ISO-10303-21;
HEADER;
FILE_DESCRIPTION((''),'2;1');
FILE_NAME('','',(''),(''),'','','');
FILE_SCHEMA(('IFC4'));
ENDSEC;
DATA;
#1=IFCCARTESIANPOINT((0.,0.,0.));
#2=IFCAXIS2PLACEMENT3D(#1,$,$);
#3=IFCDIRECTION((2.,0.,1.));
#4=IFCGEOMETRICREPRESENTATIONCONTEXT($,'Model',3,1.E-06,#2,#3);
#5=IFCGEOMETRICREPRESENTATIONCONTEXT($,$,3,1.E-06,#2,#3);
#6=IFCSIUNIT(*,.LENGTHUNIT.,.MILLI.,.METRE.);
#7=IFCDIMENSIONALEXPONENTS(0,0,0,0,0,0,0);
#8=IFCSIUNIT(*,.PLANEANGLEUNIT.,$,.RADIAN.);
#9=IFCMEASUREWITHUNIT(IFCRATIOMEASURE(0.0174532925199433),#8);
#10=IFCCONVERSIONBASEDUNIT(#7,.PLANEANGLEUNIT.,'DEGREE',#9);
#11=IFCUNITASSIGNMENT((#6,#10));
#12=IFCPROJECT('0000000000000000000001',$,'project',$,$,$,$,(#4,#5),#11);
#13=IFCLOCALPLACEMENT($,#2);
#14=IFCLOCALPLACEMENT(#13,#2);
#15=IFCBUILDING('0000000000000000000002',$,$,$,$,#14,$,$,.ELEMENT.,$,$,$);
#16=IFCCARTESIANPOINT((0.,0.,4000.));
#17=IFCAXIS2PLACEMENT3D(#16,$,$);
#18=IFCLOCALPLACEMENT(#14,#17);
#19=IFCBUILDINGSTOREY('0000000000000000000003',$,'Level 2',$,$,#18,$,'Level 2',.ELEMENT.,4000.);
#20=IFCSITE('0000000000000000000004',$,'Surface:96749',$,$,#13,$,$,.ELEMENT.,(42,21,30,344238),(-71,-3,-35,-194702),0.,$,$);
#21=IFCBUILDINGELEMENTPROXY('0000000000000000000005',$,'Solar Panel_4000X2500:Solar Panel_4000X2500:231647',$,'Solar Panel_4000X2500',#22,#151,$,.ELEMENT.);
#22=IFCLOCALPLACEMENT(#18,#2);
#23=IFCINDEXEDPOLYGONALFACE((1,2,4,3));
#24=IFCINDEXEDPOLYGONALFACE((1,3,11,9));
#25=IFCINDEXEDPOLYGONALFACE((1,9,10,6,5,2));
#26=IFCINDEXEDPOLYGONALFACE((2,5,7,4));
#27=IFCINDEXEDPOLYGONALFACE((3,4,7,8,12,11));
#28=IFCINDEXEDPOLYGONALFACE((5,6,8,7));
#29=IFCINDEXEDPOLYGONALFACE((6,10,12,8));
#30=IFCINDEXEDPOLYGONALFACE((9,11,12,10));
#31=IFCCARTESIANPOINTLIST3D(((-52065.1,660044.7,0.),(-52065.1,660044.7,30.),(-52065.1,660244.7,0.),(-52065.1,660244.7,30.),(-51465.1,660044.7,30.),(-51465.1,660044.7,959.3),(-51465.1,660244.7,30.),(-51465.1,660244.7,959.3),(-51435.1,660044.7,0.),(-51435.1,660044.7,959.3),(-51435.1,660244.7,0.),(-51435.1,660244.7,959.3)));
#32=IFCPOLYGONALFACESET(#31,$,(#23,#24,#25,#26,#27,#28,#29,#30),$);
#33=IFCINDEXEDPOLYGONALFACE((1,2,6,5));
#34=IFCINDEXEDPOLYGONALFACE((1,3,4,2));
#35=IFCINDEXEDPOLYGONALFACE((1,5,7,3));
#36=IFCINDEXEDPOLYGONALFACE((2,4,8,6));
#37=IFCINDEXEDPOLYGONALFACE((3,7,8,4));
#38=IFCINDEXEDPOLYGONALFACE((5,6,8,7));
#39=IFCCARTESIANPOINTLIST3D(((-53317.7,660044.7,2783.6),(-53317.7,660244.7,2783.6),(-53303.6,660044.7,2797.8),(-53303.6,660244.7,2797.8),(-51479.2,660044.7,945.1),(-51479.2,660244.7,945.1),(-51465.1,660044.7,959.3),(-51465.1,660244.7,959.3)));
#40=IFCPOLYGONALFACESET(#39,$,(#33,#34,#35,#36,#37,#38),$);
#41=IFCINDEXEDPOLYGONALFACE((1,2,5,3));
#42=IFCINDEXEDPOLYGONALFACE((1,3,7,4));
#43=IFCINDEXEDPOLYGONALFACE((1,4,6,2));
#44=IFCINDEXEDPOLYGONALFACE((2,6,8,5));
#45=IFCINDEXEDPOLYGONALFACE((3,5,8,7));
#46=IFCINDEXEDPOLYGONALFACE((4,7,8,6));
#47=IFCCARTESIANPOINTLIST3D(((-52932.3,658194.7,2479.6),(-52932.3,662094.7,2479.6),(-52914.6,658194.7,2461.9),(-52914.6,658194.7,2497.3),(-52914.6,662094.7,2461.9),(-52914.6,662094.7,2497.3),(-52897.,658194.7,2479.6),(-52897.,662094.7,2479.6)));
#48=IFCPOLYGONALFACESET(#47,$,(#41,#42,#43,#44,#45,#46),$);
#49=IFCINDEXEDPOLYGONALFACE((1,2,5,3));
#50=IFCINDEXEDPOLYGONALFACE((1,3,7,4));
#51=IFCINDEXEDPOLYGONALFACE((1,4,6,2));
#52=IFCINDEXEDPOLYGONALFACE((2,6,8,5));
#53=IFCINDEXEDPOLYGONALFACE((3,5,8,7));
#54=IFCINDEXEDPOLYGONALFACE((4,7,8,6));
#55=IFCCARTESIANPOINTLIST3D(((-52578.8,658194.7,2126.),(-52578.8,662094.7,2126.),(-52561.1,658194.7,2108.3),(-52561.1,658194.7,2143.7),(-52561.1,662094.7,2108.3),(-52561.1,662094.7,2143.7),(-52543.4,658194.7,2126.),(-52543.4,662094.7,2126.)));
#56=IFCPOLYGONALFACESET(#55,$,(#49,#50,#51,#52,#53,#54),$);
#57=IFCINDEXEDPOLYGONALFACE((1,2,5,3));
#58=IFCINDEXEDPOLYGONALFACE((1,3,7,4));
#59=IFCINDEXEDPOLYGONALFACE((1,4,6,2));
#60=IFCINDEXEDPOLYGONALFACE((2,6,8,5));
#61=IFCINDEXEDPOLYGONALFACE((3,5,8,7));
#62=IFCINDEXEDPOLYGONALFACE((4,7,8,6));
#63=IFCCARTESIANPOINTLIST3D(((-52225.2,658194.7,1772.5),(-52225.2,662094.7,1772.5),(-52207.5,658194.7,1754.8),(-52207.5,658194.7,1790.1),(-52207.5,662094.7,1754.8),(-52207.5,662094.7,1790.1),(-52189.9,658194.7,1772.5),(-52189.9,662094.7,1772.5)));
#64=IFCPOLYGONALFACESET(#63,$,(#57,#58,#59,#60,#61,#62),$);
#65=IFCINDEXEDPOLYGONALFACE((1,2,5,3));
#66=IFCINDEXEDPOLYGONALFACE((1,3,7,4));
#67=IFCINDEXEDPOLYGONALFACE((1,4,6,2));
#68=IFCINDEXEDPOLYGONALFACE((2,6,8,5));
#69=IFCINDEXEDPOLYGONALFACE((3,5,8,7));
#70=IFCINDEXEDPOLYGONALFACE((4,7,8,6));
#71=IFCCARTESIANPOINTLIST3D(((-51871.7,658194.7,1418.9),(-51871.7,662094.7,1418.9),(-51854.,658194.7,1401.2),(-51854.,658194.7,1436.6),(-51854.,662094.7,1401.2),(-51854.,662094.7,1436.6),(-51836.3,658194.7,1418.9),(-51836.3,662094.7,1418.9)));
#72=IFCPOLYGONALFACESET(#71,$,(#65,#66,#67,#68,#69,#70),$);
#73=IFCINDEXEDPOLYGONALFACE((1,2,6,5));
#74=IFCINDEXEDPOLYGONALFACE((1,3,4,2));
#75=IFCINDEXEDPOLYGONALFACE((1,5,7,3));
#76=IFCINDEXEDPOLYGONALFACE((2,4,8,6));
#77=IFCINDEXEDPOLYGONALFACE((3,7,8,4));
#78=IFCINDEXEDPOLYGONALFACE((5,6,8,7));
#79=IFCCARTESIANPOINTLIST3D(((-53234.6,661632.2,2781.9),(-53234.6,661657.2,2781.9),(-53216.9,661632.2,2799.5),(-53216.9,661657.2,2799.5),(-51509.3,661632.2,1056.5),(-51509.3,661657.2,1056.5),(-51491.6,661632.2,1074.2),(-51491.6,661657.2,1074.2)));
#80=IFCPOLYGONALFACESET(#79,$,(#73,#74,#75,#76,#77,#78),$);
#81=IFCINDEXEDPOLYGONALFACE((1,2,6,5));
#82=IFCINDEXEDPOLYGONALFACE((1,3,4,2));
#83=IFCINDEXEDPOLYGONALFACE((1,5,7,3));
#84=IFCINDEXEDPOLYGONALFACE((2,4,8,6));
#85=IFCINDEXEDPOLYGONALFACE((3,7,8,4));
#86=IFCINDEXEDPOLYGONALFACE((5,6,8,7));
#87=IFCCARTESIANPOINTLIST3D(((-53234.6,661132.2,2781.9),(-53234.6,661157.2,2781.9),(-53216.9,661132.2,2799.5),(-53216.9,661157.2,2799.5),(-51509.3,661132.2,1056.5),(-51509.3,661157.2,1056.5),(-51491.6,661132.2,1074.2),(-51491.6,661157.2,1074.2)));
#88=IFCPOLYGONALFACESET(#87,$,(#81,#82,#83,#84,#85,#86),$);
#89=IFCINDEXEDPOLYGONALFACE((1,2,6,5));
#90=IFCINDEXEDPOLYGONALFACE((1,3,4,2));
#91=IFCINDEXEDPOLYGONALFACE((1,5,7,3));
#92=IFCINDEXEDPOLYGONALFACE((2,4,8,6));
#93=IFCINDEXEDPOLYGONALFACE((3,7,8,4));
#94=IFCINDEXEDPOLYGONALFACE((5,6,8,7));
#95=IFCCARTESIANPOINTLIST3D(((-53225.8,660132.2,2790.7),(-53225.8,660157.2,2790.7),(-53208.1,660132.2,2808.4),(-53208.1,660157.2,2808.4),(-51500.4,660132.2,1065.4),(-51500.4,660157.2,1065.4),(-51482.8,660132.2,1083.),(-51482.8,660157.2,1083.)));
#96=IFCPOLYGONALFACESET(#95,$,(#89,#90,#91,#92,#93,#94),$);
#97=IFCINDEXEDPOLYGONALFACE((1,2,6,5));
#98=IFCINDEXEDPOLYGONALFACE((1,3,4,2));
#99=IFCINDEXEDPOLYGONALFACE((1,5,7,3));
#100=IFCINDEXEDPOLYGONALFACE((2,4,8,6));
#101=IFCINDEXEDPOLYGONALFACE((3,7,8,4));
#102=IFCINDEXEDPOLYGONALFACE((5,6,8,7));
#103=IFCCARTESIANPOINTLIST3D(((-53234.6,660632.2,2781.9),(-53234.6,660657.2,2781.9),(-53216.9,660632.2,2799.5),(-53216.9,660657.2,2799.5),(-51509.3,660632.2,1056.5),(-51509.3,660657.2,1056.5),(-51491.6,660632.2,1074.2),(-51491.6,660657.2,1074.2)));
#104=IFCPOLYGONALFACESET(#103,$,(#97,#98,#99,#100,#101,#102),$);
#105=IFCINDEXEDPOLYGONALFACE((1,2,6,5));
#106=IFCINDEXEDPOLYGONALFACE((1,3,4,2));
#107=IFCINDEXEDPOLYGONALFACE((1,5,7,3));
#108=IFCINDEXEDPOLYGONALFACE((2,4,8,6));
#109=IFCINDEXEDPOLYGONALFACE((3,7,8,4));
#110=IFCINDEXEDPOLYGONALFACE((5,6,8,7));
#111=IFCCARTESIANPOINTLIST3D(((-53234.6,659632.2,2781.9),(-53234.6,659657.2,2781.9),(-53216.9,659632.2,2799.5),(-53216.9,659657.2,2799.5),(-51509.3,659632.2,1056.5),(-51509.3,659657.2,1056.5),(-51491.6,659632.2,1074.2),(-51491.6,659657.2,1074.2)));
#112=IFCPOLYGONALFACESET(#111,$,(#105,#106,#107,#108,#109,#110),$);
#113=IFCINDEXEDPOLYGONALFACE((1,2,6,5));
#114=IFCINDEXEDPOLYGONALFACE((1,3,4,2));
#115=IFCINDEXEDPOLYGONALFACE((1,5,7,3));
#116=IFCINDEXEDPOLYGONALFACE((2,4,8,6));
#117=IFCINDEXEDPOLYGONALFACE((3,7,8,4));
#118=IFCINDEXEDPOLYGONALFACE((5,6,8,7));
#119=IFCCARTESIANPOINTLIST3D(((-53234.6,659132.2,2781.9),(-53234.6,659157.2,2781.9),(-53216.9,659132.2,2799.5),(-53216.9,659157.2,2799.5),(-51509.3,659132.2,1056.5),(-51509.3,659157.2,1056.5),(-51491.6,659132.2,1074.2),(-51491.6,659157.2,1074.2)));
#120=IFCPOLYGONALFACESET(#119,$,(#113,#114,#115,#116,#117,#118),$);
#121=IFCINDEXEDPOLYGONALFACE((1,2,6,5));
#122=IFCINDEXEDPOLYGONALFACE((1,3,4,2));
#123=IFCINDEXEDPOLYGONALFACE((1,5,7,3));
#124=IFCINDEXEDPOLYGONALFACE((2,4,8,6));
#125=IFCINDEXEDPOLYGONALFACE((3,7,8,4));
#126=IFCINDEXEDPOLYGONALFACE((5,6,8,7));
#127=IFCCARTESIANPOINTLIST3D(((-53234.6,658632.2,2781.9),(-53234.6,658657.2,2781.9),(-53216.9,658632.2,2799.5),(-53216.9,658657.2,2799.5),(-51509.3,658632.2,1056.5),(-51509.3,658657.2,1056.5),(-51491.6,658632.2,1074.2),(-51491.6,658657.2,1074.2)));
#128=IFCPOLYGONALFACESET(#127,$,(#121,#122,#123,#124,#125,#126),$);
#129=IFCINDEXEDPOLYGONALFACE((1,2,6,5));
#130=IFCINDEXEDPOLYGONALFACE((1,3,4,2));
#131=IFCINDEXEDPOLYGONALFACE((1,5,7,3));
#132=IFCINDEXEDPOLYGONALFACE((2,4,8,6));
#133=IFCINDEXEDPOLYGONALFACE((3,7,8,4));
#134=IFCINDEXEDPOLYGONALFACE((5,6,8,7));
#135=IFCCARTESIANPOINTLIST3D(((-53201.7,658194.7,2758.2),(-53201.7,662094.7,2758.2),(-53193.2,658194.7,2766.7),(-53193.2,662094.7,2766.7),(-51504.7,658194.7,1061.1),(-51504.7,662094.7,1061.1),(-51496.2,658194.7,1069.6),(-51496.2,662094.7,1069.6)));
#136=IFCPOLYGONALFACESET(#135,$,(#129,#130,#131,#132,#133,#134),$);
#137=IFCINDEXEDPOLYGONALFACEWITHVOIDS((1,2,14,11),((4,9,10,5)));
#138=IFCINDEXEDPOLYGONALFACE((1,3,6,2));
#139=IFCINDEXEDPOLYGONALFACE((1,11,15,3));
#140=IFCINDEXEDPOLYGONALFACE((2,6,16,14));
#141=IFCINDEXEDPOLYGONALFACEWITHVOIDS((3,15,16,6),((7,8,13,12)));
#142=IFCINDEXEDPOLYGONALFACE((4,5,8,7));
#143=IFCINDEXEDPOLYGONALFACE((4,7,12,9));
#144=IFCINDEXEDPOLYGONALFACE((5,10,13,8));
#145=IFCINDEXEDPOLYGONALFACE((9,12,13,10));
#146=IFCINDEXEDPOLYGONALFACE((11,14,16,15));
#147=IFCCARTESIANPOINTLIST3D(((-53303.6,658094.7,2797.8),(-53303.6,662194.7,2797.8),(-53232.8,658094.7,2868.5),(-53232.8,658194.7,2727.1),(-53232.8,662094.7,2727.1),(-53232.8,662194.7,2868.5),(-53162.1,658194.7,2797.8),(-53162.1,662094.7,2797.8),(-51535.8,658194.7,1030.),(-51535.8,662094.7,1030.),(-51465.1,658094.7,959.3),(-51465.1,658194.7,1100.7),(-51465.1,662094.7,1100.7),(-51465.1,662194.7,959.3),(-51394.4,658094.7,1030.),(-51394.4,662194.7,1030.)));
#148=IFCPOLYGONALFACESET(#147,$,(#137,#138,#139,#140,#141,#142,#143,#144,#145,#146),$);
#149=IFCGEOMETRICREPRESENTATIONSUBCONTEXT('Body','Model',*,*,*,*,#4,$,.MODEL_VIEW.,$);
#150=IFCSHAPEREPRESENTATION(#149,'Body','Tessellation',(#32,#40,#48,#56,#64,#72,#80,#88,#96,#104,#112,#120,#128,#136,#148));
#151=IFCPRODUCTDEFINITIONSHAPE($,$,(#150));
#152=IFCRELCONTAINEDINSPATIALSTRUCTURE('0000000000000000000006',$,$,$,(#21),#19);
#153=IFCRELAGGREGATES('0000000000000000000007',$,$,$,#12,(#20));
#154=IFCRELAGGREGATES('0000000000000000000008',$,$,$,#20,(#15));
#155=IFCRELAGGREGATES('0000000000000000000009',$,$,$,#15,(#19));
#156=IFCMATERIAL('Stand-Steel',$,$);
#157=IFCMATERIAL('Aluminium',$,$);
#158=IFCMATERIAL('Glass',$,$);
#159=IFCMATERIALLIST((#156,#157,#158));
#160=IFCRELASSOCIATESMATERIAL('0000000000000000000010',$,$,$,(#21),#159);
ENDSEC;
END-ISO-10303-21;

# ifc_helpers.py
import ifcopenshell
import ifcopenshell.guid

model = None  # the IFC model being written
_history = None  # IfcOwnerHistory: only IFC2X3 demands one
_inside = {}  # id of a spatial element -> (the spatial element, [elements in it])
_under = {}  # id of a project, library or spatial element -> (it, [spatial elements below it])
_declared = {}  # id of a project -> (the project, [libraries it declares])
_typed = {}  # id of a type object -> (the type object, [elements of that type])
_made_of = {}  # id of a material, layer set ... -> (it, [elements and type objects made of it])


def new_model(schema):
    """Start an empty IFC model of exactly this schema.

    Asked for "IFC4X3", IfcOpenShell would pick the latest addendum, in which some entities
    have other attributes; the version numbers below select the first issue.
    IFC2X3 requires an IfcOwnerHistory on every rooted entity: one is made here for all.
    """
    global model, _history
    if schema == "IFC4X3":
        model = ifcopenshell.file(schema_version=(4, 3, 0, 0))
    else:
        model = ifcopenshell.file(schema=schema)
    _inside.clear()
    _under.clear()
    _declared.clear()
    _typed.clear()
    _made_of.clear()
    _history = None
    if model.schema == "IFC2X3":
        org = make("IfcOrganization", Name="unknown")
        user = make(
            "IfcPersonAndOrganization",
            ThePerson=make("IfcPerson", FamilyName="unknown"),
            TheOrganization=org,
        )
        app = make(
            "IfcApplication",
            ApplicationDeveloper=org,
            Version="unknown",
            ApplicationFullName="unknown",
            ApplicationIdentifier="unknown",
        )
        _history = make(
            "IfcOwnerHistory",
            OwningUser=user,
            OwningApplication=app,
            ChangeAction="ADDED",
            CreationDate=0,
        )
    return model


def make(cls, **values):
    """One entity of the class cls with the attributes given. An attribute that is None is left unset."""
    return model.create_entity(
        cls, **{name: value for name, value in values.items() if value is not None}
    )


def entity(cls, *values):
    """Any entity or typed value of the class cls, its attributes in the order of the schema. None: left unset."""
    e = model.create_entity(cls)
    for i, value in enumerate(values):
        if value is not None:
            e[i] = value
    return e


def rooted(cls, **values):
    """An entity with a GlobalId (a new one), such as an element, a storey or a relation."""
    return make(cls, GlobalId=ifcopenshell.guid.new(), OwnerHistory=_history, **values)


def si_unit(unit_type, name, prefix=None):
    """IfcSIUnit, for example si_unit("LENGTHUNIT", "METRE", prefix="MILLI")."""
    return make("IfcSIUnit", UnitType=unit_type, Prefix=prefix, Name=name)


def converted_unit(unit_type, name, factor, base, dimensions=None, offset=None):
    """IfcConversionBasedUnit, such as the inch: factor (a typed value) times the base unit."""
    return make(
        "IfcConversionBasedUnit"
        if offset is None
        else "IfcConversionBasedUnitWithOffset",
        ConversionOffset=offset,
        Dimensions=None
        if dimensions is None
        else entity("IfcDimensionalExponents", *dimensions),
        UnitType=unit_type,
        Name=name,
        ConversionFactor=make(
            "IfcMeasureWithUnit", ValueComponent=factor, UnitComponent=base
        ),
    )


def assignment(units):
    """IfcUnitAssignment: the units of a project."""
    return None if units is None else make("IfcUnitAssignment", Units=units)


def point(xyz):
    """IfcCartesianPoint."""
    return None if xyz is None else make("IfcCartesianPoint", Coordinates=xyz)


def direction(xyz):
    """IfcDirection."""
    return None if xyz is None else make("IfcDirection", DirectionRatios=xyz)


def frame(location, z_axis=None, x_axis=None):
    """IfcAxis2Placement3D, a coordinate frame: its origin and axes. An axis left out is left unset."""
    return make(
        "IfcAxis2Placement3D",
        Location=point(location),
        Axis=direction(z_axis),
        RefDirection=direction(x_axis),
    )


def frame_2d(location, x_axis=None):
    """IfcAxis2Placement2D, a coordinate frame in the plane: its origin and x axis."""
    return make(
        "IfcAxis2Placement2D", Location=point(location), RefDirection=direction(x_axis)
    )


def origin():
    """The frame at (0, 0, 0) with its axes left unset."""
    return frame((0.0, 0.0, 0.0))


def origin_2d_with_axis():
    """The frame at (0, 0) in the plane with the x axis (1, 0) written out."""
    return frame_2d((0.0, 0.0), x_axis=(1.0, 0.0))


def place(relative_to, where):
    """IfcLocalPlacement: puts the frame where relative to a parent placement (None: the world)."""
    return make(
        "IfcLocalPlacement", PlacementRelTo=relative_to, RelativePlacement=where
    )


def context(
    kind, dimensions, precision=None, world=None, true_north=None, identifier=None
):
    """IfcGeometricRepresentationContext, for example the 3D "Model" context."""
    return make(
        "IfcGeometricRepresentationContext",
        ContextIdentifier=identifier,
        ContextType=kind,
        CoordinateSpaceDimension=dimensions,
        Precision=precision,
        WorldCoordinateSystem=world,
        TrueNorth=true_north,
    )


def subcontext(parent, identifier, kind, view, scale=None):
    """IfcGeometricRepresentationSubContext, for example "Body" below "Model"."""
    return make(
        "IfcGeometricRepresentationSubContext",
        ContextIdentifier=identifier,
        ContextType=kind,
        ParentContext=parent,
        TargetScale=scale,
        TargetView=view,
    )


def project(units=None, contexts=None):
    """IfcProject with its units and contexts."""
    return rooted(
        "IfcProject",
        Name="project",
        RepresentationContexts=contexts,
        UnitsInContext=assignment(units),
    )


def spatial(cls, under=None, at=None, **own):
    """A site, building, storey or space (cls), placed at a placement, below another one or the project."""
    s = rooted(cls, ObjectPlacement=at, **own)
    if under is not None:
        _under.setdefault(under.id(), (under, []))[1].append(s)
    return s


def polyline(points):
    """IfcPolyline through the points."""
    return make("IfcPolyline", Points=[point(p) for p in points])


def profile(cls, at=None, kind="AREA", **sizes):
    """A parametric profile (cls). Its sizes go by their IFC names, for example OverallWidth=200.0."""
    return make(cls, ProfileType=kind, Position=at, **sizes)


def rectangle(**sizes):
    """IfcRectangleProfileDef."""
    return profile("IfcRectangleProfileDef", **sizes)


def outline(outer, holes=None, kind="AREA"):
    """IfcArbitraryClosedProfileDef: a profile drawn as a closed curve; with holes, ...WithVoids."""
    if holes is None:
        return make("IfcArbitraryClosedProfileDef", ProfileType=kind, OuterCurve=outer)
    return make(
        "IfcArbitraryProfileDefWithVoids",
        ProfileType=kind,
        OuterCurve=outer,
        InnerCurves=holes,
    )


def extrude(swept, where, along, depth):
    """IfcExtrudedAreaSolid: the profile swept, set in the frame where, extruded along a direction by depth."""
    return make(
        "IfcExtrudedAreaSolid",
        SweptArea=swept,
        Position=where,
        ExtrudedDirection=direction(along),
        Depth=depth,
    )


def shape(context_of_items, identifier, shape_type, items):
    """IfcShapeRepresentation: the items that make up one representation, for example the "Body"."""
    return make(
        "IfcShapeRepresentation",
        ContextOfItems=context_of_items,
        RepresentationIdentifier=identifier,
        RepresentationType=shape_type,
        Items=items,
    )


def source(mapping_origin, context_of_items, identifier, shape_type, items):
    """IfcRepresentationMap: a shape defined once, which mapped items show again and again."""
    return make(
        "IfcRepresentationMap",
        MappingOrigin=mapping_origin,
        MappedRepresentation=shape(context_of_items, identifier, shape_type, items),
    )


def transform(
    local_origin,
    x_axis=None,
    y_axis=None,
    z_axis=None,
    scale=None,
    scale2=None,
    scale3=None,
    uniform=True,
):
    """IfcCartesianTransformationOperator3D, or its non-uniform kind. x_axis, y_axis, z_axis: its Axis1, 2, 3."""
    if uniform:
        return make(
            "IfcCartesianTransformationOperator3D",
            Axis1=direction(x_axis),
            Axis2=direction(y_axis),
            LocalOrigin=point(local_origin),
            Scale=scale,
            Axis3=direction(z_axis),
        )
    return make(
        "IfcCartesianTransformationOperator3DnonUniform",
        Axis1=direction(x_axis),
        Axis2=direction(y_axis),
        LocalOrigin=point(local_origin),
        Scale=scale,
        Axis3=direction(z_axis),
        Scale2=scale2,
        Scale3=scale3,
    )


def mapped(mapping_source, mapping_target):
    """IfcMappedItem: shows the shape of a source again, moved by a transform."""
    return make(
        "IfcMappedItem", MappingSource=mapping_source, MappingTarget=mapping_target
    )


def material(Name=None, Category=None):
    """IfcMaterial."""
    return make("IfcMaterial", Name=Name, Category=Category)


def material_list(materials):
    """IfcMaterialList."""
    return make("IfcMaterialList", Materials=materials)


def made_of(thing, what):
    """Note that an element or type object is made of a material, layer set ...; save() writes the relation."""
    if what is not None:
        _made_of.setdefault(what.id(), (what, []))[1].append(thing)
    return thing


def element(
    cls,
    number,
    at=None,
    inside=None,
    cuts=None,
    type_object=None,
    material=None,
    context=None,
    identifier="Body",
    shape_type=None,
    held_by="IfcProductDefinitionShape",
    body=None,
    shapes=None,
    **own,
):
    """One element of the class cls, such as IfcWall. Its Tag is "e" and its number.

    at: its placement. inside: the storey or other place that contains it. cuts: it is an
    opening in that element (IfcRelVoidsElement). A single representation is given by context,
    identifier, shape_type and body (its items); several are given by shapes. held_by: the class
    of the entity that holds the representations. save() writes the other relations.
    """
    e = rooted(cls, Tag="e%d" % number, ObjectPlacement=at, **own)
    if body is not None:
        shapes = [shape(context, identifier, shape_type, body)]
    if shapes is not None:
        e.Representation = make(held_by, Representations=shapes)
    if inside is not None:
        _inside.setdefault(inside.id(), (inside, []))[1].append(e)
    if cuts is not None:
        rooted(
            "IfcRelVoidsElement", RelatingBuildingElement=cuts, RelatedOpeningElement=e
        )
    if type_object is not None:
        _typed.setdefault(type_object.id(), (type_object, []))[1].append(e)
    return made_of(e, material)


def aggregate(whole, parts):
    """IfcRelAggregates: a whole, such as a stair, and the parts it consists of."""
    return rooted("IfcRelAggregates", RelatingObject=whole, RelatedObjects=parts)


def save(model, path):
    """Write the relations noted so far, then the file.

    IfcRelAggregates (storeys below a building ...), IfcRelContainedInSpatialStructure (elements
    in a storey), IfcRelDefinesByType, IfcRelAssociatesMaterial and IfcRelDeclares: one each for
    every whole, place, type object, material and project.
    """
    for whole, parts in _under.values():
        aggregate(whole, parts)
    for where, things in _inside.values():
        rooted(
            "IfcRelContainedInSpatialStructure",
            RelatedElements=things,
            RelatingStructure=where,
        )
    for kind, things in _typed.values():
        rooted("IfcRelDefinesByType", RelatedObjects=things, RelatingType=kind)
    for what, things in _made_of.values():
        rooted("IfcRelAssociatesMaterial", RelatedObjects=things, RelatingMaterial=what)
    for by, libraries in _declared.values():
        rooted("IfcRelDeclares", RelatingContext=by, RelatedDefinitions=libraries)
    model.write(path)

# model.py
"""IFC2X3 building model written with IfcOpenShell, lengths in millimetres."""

from ifc_helpers import new_model, entity, si_unit, converted_unit, direction, frame, frame_2d, origin, origin_2d_with_axis, place, context, subcontext, project, spatial, polyline, rectangle, outline, extrude, source, transform, mapped, material, material_list, element, save


model = new_model("IFC2X3")

# Units and contexts
model_context = context("Model", 3, precision=1e-06, world=origin(), true_north=direction((2.0, 0.0, 1.0)))
context_of_model = context(None, 3, precision=1e-06, world=origin(), true_north=direction((2.0, 0.0, 1.0)))
body_context = subcontext(model_context, "Body", "Model", "MODEL_VIEW")
ifc_project = project(units=[si_unit("LENGTHUNIT", "METRE", prefix="MILLI"), converted_unit("PLANEANGLEUNIT", "DEGREE", entity("IfcRatioMeasure", 0.0174532925199433), si_unit("PLANEANGLEUNIT", "RADIAN"), dimensions=[0, 0, 0, 0, 0, 0, 0])], contexts=[model_context, context_of_model])

# Site, building, storey
site_placement = place(None, origin())
site = spatial("IfcSite", under=ifc_project, at=site_placement, Name="Surface:96749", CompositionType="ELEMENT", RefLatitude=(42, 21, 30, 344238), RefLongitude=(-71, -3, -35, -194702), RefElevation=0.0)
building_placement = place(site_placement, origin())
building = spatial("IfcBuilding", under=site, at=building_placement, CompositionType="ELEMENT")
storey_placement = place(building_placement, frame((0.0, 0.0, 4000.0)))
storey = spatial("IfcBuildingStorey", under=building, at=storey_placement, Name="Level 2", LongName="Level 2", CompositionType="ELEMENT", Elevation=4000.0)

# Building element proxy
ifc_material_1 = material(Name="Stand-Steel")
ifc_material_2 = material(Name="Aluminium")
ifc_material_3 = material(Name="Glass")
shared_shape = source(origin(), body_context, "Body", "SweptSolid", [
    extrude(outline(polyline([(-629.5, -220.0), (329.8, -220.0), (329.8, 410.0), (299.8, 410.0), (299.8, -190.0), (-629.5, -190.0), (-629.5, -220.0)])), frame((-190.0, -100.0, 299.8), z_axis=(0.0, 1.0, 0.0), x_axis=(0.0, 0.0, -1.0)), (0.0, 0.0, 1.0), 200.0),
    extrude(rectangle(XDim=20.0, YDim=200.0, at=frame_2d((0.0, 0.0), x_axis=(0.0, 1.0))), frame((-7.1, 0.0, 922.2), z_axis=(-0.707107, 0.0, 0.707107), x_axis=(0.0, 1.0, 0.0)), (0.0, 0.0, 1.0), 2600.0),
    extrude(rectangle(XDim=25.0, YDim=25.0, at=frame_2d((0.0, 0.0), x_axis=(1.0, 0.0))), frame((-1449.6, -1950.0, 2449.6), z_axis=(0.0, 1.0, 0.0), x_axis=(-0.707107, 0.0, -0.707107)), (0.0, 0.0, 1.0), 3900.0),
    extrude(rectangle(XDim=25.0, YDim=25.0, at=origin_2d_with_axis()), frame((-1096.0, -1950.0, 2096.0), z_axis=(0.0, 1.0, 0.0), x_axis=(-0.707107, 0.0, -0.707107)), (0.0, 0.0, 1.0), 3900.0),
    extrude(rectangle(XDim=25.0, YDim=25.0, at=origin_2d_with_axis()), frame((-742.5, -1950.0, 1742.5), z_axis=(0.0, 1.0, 0.0), x_axis=(-0.707107, 0.0, -0.707107)), (0.0, 0.0, 1.0), 3900.0),
    extrude(rectangle(XDim=25.0, YDim=25.0, at=frame_2d((0.0, 0.0), x_axis=(1.0, 0.0))), frame((-388.9, -1950.0, 1388.9), z_axis=(0.0, 1.0, 0.0), x_axis=(-0.707107, 0.0, -0.707107)), (0.0, 0.0, 1.0), 3900.0),
    extrude(rectangle(XDim=25.0, YDim=25.0, at=frame_2d((0.0, 0.0), x_axis=(0.0, 1.0))), frame((-35.4, 1500.0, 1035.4), z_axis=(-0.707107, 0.0, 0.707107), x_axis=(0.0, 1.0, 0.0)), (0.0, 0.0, 1.0), 2440.0),
    extrude(rectangle(XDim=25.0, YDim=25.0, at=frame_2d((0.0, 0.0), x_axis=(0.0, 1.0))), frame((-35.4, 1000.0, 1035.4), z_axis=(-0.707107, 0.0, 0.707107), x_axis=(0.0, 1.0, 0.0)), (0.0, 0.0, 1.0), 2440.0),
    extrude(rectangle(XDim=25.0, YDim=25.0, at=frame_2d((0.0, 0.0), x_axis=(0.0, 1.0))), frame((-26.5, 0.0, 1044.2), z_axis=(-0.707107, 0.0, 0.707107), x_axis=(0.0, -1.0, 0.0)), (0.0, 0.0, 1.0), 2440.0),
    extrude(rectangle(XDim=25.0, YDim=25.0, at=frame_2d((0.0, 0.0), x_axis=(0.0, 1.0))), frame((-35.4, 500.0, 1035.4), z_axis=(-0.707107, 0.0, 0.707107), x_axis=(0.0, 1.0, 0.0)), (0.0, 0.0, 1.0), 2440.0),
    extrude(rectangle(XDim=25.0, YDim=25.0, at=frame_2d((0.0, 0.0), x_axis=(0.0, 1.0))), frame((-35.4, -500.0, 1035.4), z_axis=(-0.707107, 0.0, 0.707107), x_axis=(0.0, 1.0, 0.0)), (0.0, 0.0, 1.0), 2440.0),
    extrude(rectangle(XDim=25.0, YDim=25.0, at=frame_2d((0.0, 0.0), x_axis=(0.0, 1.0))), frame((-35.4, -1000.0, 1035.4), z_axis=(-0.707107, 0.0, 0.707107), x_axis=(0.0, 1.0, 0.0)), (0.0, 0.0, 1.0), 2440.0),
    extrude(rectangle(XDim=25.0, YDim=25.0, at=frame_2d((0.0, 0.0), x_axis=(0.0, 1.0))), frame((-35.4, -1500.0, 1035.4), z_axis=(-0.707107, 0.0, 0.707107), x_axis=(0.0, 1.0, 0.0)), (0.0, 0.0, 1.0), 2440.0),
    extrude(rectangle(XDim=2400.0, YDim=12.0, at=frame_2d((0.0, 0.0), x_axis=(1.0, 0.0))), frame((-883.9, -1950.0, 1883.9), z_axis=(0.0, 1.0, 0.0), x_axis=(0.707107, 0.0, -0.707107)), (0.0, 0.0, 1.0), 3900.0),
    extrude(outline(polyline([(-2050.0, -1300.0), (2050.0, -1300.0), (2050.0, 1300.0), (-2050.0, 1300.0), (-2050.0, -1300.0)]), holes=[polyline([(1950.0, -1200.0), (-1950.0, -1200.0), (-1950.0, 1200.0), (1950.0, 1200.0), (1950.0, -1200.0)])]), frame((-919.2, 0.0, 1848.5), z_axis=(0.707107, 0.0, 0.707107), x_axis=(0.0, 1.0, 0.0)), (0.0, 0.0, 1.0), 100.0),
])
ifc_material_list_1 = material_list([ifc_material_1, ifc_material_2, ifc_material_3])
proxy_1_placement = place(storey_placement, frame((-51465.1, 660144.7, 30.0)))
element("IfcBuildingElementProxy", 1, at=proxy_1_placement, inside=storey, material=ifc_material_list_1, Name="Solar Panel_4000X2500:Solar Panel_4000X2500:231647", ObjectType="Solar Panel_4000X2500", CompositionType="ELEMENT", context=body_context, shape_type="MappedRepresentation", body=[
    mapped(shared_shape, transform((0.0, 0.0, 0.0), scale=1.0)),
])

save(model, "model.ifc")
